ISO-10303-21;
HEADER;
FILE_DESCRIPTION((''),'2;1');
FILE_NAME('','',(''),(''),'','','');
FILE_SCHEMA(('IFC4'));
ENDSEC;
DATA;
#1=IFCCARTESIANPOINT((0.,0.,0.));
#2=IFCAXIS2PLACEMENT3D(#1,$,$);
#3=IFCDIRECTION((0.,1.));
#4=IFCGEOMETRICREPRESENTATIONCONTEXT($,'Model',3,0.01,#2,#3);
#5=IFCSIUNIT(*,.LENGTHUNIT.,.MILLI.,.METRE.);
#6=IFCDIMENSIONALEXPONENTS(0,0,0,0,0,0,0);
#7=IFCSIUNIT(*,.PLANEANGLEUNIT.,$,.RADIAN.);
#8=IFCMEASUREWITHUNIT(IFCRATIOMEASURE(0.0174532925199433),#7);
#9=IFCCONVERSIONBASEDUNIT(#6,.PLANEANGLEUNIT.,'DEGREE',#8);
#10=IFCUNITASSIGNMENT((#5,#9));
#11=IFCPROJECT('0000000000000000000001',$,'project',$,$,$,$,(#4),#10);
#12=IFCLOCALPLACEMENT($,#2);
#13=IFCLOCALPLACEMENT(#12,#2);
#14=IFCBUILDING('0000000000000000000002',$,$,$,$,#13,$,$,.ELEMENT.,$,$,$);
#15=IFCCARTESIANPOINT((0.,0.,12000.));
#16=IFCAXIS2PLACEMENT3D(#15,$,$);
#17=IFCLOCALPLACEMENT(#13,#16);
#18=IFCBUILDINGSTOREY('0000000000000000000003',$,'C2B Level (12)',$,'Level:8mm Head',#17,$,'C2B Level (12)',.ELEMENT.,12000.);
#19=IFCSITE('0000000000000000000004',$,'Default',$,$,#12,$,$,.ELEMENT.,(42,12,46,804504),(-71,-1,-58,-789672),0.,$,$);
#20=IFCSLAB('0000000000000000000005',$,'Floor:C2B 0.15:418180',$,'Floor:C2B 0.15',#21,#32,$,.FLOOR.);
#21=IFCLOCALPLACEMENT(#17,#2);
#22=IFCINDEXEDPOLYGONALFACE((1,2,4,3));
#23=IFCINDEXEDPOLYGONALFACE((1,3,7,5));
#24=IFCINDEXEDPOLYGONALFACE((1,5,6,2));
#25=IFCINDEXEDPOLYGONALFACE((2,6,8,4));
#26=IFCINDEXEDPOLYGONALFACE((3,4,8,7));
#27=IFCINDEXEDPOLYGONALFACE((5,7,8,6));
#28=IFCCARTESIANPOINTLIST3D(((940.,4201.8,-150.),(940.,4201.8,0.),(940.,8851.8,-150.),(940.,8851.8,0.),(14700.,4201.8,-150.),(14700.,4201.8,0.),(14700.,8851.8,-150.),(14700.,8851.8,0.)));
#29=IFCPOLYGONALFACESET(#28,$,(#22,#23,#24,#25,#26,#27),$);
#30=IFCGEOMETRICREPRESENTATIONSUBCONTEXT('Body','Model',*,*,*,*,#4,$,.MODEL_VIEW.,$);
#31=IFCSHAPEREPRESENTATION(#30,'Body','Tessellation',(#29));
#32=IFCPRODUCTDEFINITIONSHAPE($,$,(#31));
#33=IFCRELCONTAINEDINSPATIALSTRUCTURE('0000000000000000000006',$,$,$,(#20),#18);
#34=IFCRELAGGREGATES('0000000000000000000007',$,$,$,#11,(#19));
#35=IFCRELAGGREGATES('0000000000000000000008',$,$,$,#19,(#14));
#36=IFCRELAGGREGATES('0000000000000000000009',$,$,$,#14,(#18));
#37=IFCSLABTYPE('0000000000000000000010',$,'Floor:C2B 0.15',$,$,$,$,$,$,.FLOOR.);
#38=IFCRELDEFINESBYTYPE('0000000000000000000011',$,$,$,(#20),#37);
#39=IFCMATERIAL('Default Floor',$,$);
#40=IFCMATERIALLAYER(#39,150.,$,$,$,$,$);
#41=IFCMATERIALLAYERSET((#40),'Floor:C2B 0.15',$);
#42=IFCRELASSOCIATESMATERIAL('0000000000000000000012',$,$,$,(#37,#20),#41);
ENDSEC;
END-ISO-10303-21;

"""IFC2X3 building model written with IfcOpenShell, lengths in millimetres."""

from ifc_helpers import new_model, entity, si_unit, converted_unit, direction, frame, origin, origin_2d_with_axis, place, context, subcontext, project, spatial, rectangle, extrude, material, layer, layer_set, layer_usage, type_object, element, save


model = new_model("IFC2X3")

# Units and contexts
model_context = context("Model", 3, precision=0.01, world=origin(), true_north=direction((0.0, 1.0)))
body_context = subcontext(model_context, "Body", "Model", "MODEL_VIEW")
ifc_project = project(units=[si_unit("LENGTHUNIT", "METRE", prefix="MILLI"), converted_unit("PLANEANGLEUNIT", "DEGREE", entity("IfcRatioMeasure", 0.0174532925199433), si_unit("PLANEANGLEUNIT", "RADIAN"), dimensions=[0, 0, 0, 0, 0, 0, 0])], contexts=[model_context])

# Site, building, storey
site_placement = place(None, origin())
site = spatial("IfcSite", under=ifc_project, at=site_placement, Name="Default", CompositionType="ELEMENT", RefLatitude=(42, 12, 46, 804504), RefLongitude=(-71, -1, -58, -789672), RefElevation=0.0)
building_placement = place(site_placement, origin())
building = spatial("IfcBuilding", under=site, at=building_placement, CompositionType="ELEMENT")
storey_placement = place(building_placement, frame((0.0, 0.0, 12000.0)))
storey = spatial("IfcBuildingStorey", under=building, at=storey_placement, Name="C2B Level (12)", ObjectType="Level:8mm Head", LongName="C2B Level (12)", CompositionType="ELEMENT", Elevation=12000.0)

# Slab
ifc_material_1 = material(Name="Default Floor")
ifc_layer = layer(ifc_material_1, 150.0)
ifc_layer_set = layer_set([ifc_layer], Name="Floor:C2B 0.15")
ifc_layer_usage = layer_usage(ifc_layer_set, "AXIS3", "POSITIVE", 0.0)
slab_type = type_object("IfcSlabType", Name="Floor:C2B 0.15", PredefinedType="FLOOR", material=ifc_layer_set)
slab_placement = place(storey_placement, origin())
element("IfcSlab", 1, at=slab_placement, inside=storey, type_object=slab_type, material=ifc_layer_usage, Name="Floor:C2B 0.15:418180", ObjectType="Floor:C2B 0.15", PredefinedType="FLOOR", context=body_context, shape_type="SweptSolid", body=[
    extrude(rectangle(XDim=4650.0, YDim=13760.0, at=origin_2d_with_axis()), frame((7820.0, 6526.8, 0.0), z_axis=(0.0, 0.0, -1.0), x_axis=(0.0, 1.0, 0.0)), (0.0, 0.0, 1.0), 150.0),
])

save(model, "model.ifc")
